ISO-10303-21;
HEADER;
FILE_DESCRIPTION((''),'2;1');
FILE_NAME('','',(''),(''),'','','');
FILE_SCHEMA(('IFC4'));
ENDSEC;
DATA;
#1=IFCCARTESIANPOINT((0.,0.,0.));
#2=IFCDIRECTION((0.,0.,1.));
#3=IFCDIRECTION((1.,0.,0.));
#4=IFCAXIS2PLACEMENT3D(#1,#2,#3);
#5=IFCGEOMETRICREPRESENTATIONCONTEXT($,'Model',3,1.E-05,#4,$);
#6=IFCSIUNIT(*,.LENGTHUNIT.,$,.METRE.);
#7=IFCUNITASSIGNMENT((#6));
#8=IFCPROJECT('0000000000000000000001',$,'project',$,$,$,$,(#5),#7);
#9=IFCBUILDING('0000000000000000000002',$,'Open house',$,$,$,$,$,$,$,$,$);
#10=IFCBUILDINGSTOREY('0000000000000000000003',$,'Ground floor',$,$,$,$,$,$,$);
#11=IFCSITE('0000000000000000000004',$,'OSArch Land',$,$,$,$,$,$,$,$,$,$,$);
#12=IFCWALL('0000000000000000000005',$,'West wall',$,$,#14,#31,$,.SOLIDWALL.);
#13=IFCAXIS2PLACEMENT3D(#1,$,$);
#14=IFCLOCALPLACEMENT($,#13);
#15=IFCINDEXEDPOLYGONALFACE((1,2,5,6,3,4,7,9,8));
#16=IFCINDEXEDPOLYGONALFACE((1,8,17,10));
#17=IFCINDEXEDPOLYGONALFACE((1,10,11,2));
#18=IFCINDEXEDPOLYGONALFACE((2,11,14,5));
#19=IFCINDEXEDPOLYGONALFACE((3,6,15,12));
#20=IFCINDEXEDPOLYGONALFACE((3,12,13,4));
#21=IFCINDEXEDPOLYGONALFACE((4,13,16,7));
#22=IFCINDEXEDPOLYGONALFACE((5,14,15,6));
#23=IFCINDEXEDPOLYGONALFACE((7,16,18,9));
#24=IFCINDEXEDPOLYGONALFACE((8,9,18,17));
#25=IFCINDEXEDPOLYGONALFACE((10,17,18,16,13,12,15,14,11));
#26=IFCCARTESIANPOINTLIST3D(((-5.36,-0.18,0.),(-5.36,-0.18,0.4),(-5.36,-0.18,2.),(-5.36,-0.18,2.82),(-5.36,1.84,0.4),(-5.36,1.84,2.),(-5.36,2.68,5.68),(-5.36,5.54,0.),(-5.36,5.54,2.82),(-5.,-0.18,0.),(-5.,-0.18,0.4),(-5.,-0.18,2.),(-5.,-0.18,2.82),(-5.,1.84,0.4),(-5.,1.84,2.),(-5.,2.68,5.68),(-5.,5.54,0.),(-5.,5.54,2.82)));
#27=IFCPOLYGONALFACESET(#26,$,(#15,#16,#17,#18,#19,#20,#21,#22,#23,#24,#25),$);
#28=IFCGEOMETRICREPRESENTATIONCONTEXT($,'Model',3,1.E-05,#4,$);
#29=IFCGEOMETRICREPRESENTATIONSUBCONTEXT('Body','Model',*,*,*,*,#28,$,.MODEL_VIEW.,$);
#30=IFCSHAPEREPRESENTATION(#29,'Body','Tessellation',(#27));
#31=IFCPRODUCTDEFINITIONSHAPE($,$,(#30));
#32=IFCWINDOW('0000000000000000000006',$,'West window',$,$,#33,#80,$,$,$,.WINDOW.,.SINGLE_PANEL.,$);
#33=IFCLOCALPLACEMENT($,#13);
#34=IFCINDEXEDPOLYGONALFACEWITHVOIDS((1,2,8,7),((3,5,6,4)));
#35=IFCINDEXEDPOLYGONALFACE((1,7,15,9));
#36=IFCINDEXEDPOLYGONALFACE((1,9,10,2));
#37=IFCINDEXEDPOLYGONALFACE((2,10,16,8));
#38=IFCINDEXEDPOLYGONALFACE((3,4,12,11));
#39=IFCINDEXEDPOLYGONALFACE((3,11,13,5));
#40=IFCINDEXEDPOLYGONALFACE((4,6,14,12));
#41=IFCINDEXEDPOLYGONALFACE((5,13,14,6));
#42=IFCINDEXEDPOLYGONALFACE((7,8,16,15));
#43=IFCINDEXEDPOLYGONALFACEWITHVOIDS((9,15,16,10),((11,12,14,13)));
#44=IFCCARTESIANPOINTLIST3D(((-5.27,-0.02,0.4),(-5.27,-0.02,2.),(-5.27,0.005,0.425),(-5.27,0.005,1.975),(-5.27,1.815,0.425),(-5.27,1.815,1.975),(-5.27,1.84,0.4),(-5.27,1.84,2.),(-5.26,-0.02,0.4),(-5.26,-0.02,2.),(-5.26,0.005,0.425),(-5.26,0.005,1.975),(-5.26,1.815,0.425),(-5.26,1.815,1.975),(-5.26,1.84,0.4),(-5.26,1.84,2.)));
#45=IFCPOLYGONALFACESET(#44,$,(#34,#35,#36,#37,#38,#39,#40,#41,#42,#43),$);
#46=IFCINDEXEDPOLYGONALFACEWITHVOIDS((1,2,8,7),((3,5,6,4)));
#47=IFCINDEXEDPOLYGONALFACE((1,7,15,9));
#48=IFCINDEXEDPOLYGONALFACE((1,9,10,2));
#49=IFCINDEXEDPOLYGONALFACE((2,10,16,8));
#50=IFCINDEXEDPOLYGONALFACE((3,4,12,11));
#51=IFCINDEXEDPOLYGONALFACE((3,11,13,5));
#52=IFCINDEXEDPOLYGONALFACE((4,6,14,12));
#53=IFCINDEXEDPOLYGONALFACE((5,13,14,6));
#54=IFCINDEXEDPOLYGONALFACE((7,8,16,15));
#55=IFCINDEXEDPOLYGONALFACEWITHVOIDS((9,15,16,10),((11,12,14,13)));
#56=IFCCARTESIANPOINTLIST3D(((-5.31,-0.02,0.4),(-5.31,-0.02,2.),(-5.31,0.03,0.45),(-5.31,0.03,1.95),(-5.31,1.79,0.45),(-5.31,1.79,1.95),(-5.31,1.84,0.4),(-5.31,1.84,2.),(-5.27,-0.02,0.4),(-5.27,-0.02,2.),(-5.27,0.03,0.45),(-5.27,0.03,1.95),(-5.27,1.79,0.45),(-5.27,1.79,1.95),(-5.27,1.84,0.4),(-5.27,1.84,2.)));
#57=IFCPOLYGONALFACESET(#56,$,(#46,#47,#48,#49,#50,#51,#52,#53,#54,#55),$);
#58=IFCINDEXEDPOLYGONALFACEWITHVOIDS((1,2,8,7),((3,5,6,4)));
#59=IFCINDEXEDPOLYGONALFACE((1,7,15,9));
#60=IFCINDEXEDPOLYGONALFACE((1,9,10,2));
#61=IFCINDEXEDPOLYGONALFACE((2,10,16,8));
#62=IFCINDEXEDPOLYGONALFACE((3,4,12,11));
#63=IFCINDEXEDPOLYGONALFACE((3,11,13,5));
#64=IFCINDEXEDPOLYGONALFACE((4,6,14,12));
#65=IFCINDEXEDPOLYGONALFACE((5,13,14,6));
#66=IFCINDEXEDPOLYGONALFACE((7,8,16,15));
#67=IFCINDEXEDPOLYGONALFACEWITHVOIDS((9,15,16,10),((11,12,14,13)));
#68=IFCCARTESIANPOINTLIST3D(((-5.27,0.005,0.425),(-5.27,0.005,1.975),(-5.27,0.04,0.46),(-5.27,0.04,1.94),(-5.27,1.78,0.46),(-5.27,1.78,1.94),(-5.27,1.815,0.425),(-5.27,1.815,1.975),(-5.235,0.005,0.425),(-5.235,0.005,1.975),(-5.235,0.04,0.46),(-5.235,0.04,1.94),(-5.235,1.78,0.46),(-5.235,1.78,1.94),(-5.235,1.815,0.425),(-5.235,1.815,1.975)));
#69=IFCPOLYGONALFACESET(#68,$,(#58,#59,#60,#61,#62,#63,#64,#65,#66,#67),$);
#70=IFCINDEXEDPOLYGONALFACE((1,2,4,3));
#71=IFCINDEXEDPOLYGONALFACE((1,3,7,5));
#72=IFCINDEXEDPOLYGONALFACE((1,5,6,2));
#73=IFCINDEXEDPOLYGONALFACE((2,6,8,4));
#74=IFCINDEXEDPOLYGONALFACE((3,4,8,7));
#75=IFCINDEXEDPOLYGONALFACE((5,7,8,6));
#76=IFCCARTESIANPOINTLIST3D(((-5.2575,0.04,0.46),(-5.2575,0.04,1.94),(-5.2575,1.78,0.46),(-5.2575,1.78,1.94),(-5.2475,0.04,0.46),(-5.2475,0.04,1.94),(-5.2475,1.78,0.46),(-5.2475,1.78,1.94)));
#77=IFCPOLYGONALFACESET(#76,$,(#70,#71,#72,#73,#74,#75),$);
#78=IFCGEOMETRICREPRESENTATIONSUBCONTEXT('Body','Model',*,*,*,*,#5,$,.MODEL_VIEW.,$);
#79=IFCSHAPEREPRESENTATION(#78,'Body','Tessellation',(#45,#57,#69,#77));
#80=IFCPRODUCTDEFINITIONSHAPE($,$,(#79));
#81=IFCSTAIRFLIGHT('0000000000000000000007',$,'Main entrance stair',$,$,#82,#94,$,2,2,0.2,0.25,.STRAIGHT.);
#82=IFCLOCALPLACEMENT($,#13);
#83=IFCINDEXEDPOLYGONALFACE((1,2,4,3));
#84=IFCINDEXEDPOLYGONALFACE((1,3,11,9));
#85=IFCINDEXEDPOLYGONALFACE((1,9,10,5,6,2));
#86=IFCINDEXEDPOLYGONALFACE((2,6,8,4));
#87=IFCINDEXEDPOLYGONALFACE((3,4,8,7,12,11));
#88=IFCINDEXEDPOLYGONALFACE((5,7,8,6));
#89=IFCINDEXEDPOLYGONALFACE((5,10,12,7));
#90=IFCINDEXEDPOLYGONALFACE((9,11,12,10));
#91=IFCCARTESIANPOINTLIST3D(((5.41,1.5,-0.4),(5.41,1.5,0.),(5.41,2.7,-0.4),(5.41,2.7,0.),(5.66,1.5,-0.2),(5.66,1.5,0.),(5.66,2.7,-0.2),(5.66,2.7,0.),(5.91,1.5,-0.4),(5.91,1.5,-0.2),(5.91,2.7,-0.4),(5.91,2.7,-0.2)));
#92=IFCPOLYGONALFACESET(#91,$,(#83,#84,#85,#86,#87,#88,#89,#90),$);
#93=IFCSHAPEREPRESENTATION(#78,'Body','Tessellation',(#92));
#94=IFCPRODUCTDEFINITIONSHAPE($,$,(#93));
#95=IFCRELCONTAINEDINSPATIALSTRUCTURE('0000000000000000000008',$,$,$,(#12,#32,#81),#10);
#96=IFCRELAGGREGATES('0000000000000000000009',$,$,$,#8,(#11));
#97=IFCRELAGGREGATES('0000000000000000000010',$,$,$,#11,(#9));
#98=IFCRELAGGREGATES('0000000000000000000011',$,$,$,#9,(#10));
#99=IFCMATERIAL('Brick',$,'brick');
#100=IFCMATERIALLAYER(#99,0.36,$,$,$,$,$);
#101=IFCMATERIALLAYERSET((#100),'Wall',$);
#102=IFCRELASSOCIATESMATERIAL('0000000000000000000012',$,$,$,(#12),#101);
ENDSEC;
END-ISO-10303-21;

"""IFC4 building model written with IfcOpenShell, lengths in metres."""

from ifc_helpers import new_model, si_unit, frame, origin_with_axes, place, context, subcontext, project, spatial, line, indexed_curve, outline, extrude, clip, halfspace, material, layer, layer_set, element, fill, save


model = new_model("IFC4")

# Units and contexts
model_context_1 = context("Model", 3, precision=1e-05, world=origin_with_axes())
model_context_2 = context("Model", 3, precision=1e-05, world=origin_with_axes())
model_context_3 = context("Model", 3, precision=1e-05, world=origin_with_axes())
body_context_1 = subcontext(model_context_1, "Body", "Model", "MODEL_VIEW")
body_context_2 = subcontext(model_context_2, "Body", "Model", "MODEL_VIEW")
body_context_3 = subcontext(model_context_3, "Body", "Model", "MODEL_VIEW")
ifc_project = project(units=[si_unit("LENGTHUNIT", "METRE")], contexts=[model_context_1])

# Site, building, storey
site = spatial("IfcSite", under=ifc_project, Name="OSArch Land")
building = spatial("IfcBuilding", under=site, Name="Open house")
storey = spatial("IfcBuildingStorey", under=building, Name="Ground floor")

# Shared definitions
ifc_material = material(Name="Brick", Category="brick")
ifc_layer = layer(ifc_material, 0.36)
ifc_layer_set = layer_set([ifc_layer], Name="Wall")

# Wall, opening, window
wall_1_placement = place(None, frame((-5.36, -0.18, 0.0), z_axis=(0.0, 0.0, 1.0), x_axis=(1.0, 0.0, 0.0)))
wall_1 = element("IfcWall", 1, at=wall_1_placement, inside=storey, material=ifc_layer_set, Name="West wall", PredefinedType="SOLIDWALL", context=body_context_2, shape_type="Clipping", body=[
    clip(clip(extrude(outline(indexed_curve([(0.0, 0.0), (0.0, 5.72), (0.36, 5.72), (0.36, 0.0), (0.0, 0.0)], self_intersect=False)), origin_with_axes(), (0.0, 0.0, 1.0), 6.08), halfspace(frame((0.0, 5.54, 3.0), z_axis=(0.0, 0.707107, 0.707107), x_axis=(1.0, 0.0, 0.0)), False)), halfspace(frame((0.0, 0.18, 3.0), z_axis=(0.0, -0.707107, 0.707107), x_axis=(1.0, 0.0, 0.0)), False)),
])
opening_1_placement = place(wall_1_placement, frame((-0.45, -1.7, 0.4), z_axis=(0.0, 0.0, 1.0), x_axis=(1.0, 0.0, 0.0)))
opening_1 = element("IfcOpeningElement", 2, at=opening_1_placement, cuts=wall_1, context=body_context_3, shape_type="SweptSolid", body=[
    extrude(outline(indexed_curve([(0.0, 0.0), (0.0, 3.72), (6.0, 3.72), (6.0, 0.0), (0.0, 0.0)], self_intersect=False)), origin_with_axes(), (0.0, 0.0, 1.0), 1.6),
])
window_1_placement = place(None, frame((-5.36, 1.84, 0.4), z_axis=(0.0, 0.0, 1.0), x_axis=(0.0, -1.0, 0.0)))
window_1 = element("IfcWindow", 3, at=window_1_placement, inside=storey, Name="West window", PartitioningType="SINGLE_PANEL", PredefinedType="WINDOW", context=body_context_1, shape_type="SweptSolid", body=[
    extrude(outline(indexed_curve([(0.0, 0.0), (1.86, 0.0), (1.86, 1.6), (0.0, 1.6)], segments=[line(1, 2), line(2, 3), line(3, 4), line(4, 1)]), holes=[indexed_curve([(0.025, 0.025), (1.835, 0.025), (1.835, 1.575), (0.025, 1.575)], segments=[line(1, 2), line(2, 3), line(3, 4), line(4, 1)])]), frame((0.0, 0.09, 0.0), z_axis=(0.0, -1.0, 0.0), x_axis=(1.0, 0.0, 0.0)), (0.0, 0.0, -1.0), 0.01),
    extrude(outline(indexed_curve([(0.0, 0.0), (1.86, 0.0), (1.86, 1.6), (0.0, 1.6)], segments=[line(1, 2), line(2, 3), line(3, 4), line(4, 1)]), holes=[indexed_curve([(0.05, 0.05), (1.81, 0.05), (1.81, 1.55), (0.05, 1.55)], segments=[line(1, 2), line(2, 3), line(3, 4), line(4, 1)])]), frame((0.0, 0.05, 0.0), z_axis=(0.0, -1.0, 0.0), x_axis=(1.0, 0.0, 0.0)), (0.0, 0.0, -1.0), 0.04),
    extrude(outline(indexed_curve([(0.0, 0.0), (1.81, 0.0), (1.81, 1.55), (0.0, 1.55)], segments=[line(1, 2), line(2, 3), line(3, 4), line(4, 1)]), holes=[indexed_curve([(0.035, 0.035), (1.775, 0.035), (1.775, 1.515), (0.035, 1.515)], segments=[line(1, 2), line(2, 3), line(3, 4), line(4, 1)])]), frame((0.025, 0.09, 0.025), z_axis=(0.0, -1.0, 0.0), x_axis=(1.0, 0.0, 0.0)), (0.0, 0.0, -1.0), 0.035),
    extrude(outline(indexed_curve([(0.035, 0.035), (1.775, 0.035), (1.775, 1.515), (0.035, 1.515)], segments=[line(1, 2), line(2, 3), line(3, 4), line(4, 1)])), frame((0.025, 0.1025, 0.025), z_axis=(0.0, -1.0, 0.0), x_axis=(1.0, 0.0, 0.0)), (0.0, 0.0, -1.0), 0.01),
])
fill(opening_1, window_1)

# Stair flight
stair_flight_placement = place(None, frame((5.41, 1.5, 0.0), z_axis=(0.0, 1.0, 0.0), x_axis=(1.0, 0.0, 0.0)))
element("IfcStairFlight", 4, at=stair_flight_placement, inside=storey, Name="Main entrance stair", NumberOfRisers=2, NumberOfTreads=2, PredefinedType="STRAIGHT", RiserHeight=0.2, TreadLength=0.25, context=body_context_1, shape_type="SweptSolid", body=[
    extrude(outline(indexed_curve([(0.0, 0.0), (0.25, 0.0), (0.25, 0.2), (0.5, 0.2), (0.5, 0.4), (0.0, 0.4)], self_intersect=False)), origin_with_axes(), (0.0, 0.0, 1.0), 1.2),
])

save(model, "model.ifc")
